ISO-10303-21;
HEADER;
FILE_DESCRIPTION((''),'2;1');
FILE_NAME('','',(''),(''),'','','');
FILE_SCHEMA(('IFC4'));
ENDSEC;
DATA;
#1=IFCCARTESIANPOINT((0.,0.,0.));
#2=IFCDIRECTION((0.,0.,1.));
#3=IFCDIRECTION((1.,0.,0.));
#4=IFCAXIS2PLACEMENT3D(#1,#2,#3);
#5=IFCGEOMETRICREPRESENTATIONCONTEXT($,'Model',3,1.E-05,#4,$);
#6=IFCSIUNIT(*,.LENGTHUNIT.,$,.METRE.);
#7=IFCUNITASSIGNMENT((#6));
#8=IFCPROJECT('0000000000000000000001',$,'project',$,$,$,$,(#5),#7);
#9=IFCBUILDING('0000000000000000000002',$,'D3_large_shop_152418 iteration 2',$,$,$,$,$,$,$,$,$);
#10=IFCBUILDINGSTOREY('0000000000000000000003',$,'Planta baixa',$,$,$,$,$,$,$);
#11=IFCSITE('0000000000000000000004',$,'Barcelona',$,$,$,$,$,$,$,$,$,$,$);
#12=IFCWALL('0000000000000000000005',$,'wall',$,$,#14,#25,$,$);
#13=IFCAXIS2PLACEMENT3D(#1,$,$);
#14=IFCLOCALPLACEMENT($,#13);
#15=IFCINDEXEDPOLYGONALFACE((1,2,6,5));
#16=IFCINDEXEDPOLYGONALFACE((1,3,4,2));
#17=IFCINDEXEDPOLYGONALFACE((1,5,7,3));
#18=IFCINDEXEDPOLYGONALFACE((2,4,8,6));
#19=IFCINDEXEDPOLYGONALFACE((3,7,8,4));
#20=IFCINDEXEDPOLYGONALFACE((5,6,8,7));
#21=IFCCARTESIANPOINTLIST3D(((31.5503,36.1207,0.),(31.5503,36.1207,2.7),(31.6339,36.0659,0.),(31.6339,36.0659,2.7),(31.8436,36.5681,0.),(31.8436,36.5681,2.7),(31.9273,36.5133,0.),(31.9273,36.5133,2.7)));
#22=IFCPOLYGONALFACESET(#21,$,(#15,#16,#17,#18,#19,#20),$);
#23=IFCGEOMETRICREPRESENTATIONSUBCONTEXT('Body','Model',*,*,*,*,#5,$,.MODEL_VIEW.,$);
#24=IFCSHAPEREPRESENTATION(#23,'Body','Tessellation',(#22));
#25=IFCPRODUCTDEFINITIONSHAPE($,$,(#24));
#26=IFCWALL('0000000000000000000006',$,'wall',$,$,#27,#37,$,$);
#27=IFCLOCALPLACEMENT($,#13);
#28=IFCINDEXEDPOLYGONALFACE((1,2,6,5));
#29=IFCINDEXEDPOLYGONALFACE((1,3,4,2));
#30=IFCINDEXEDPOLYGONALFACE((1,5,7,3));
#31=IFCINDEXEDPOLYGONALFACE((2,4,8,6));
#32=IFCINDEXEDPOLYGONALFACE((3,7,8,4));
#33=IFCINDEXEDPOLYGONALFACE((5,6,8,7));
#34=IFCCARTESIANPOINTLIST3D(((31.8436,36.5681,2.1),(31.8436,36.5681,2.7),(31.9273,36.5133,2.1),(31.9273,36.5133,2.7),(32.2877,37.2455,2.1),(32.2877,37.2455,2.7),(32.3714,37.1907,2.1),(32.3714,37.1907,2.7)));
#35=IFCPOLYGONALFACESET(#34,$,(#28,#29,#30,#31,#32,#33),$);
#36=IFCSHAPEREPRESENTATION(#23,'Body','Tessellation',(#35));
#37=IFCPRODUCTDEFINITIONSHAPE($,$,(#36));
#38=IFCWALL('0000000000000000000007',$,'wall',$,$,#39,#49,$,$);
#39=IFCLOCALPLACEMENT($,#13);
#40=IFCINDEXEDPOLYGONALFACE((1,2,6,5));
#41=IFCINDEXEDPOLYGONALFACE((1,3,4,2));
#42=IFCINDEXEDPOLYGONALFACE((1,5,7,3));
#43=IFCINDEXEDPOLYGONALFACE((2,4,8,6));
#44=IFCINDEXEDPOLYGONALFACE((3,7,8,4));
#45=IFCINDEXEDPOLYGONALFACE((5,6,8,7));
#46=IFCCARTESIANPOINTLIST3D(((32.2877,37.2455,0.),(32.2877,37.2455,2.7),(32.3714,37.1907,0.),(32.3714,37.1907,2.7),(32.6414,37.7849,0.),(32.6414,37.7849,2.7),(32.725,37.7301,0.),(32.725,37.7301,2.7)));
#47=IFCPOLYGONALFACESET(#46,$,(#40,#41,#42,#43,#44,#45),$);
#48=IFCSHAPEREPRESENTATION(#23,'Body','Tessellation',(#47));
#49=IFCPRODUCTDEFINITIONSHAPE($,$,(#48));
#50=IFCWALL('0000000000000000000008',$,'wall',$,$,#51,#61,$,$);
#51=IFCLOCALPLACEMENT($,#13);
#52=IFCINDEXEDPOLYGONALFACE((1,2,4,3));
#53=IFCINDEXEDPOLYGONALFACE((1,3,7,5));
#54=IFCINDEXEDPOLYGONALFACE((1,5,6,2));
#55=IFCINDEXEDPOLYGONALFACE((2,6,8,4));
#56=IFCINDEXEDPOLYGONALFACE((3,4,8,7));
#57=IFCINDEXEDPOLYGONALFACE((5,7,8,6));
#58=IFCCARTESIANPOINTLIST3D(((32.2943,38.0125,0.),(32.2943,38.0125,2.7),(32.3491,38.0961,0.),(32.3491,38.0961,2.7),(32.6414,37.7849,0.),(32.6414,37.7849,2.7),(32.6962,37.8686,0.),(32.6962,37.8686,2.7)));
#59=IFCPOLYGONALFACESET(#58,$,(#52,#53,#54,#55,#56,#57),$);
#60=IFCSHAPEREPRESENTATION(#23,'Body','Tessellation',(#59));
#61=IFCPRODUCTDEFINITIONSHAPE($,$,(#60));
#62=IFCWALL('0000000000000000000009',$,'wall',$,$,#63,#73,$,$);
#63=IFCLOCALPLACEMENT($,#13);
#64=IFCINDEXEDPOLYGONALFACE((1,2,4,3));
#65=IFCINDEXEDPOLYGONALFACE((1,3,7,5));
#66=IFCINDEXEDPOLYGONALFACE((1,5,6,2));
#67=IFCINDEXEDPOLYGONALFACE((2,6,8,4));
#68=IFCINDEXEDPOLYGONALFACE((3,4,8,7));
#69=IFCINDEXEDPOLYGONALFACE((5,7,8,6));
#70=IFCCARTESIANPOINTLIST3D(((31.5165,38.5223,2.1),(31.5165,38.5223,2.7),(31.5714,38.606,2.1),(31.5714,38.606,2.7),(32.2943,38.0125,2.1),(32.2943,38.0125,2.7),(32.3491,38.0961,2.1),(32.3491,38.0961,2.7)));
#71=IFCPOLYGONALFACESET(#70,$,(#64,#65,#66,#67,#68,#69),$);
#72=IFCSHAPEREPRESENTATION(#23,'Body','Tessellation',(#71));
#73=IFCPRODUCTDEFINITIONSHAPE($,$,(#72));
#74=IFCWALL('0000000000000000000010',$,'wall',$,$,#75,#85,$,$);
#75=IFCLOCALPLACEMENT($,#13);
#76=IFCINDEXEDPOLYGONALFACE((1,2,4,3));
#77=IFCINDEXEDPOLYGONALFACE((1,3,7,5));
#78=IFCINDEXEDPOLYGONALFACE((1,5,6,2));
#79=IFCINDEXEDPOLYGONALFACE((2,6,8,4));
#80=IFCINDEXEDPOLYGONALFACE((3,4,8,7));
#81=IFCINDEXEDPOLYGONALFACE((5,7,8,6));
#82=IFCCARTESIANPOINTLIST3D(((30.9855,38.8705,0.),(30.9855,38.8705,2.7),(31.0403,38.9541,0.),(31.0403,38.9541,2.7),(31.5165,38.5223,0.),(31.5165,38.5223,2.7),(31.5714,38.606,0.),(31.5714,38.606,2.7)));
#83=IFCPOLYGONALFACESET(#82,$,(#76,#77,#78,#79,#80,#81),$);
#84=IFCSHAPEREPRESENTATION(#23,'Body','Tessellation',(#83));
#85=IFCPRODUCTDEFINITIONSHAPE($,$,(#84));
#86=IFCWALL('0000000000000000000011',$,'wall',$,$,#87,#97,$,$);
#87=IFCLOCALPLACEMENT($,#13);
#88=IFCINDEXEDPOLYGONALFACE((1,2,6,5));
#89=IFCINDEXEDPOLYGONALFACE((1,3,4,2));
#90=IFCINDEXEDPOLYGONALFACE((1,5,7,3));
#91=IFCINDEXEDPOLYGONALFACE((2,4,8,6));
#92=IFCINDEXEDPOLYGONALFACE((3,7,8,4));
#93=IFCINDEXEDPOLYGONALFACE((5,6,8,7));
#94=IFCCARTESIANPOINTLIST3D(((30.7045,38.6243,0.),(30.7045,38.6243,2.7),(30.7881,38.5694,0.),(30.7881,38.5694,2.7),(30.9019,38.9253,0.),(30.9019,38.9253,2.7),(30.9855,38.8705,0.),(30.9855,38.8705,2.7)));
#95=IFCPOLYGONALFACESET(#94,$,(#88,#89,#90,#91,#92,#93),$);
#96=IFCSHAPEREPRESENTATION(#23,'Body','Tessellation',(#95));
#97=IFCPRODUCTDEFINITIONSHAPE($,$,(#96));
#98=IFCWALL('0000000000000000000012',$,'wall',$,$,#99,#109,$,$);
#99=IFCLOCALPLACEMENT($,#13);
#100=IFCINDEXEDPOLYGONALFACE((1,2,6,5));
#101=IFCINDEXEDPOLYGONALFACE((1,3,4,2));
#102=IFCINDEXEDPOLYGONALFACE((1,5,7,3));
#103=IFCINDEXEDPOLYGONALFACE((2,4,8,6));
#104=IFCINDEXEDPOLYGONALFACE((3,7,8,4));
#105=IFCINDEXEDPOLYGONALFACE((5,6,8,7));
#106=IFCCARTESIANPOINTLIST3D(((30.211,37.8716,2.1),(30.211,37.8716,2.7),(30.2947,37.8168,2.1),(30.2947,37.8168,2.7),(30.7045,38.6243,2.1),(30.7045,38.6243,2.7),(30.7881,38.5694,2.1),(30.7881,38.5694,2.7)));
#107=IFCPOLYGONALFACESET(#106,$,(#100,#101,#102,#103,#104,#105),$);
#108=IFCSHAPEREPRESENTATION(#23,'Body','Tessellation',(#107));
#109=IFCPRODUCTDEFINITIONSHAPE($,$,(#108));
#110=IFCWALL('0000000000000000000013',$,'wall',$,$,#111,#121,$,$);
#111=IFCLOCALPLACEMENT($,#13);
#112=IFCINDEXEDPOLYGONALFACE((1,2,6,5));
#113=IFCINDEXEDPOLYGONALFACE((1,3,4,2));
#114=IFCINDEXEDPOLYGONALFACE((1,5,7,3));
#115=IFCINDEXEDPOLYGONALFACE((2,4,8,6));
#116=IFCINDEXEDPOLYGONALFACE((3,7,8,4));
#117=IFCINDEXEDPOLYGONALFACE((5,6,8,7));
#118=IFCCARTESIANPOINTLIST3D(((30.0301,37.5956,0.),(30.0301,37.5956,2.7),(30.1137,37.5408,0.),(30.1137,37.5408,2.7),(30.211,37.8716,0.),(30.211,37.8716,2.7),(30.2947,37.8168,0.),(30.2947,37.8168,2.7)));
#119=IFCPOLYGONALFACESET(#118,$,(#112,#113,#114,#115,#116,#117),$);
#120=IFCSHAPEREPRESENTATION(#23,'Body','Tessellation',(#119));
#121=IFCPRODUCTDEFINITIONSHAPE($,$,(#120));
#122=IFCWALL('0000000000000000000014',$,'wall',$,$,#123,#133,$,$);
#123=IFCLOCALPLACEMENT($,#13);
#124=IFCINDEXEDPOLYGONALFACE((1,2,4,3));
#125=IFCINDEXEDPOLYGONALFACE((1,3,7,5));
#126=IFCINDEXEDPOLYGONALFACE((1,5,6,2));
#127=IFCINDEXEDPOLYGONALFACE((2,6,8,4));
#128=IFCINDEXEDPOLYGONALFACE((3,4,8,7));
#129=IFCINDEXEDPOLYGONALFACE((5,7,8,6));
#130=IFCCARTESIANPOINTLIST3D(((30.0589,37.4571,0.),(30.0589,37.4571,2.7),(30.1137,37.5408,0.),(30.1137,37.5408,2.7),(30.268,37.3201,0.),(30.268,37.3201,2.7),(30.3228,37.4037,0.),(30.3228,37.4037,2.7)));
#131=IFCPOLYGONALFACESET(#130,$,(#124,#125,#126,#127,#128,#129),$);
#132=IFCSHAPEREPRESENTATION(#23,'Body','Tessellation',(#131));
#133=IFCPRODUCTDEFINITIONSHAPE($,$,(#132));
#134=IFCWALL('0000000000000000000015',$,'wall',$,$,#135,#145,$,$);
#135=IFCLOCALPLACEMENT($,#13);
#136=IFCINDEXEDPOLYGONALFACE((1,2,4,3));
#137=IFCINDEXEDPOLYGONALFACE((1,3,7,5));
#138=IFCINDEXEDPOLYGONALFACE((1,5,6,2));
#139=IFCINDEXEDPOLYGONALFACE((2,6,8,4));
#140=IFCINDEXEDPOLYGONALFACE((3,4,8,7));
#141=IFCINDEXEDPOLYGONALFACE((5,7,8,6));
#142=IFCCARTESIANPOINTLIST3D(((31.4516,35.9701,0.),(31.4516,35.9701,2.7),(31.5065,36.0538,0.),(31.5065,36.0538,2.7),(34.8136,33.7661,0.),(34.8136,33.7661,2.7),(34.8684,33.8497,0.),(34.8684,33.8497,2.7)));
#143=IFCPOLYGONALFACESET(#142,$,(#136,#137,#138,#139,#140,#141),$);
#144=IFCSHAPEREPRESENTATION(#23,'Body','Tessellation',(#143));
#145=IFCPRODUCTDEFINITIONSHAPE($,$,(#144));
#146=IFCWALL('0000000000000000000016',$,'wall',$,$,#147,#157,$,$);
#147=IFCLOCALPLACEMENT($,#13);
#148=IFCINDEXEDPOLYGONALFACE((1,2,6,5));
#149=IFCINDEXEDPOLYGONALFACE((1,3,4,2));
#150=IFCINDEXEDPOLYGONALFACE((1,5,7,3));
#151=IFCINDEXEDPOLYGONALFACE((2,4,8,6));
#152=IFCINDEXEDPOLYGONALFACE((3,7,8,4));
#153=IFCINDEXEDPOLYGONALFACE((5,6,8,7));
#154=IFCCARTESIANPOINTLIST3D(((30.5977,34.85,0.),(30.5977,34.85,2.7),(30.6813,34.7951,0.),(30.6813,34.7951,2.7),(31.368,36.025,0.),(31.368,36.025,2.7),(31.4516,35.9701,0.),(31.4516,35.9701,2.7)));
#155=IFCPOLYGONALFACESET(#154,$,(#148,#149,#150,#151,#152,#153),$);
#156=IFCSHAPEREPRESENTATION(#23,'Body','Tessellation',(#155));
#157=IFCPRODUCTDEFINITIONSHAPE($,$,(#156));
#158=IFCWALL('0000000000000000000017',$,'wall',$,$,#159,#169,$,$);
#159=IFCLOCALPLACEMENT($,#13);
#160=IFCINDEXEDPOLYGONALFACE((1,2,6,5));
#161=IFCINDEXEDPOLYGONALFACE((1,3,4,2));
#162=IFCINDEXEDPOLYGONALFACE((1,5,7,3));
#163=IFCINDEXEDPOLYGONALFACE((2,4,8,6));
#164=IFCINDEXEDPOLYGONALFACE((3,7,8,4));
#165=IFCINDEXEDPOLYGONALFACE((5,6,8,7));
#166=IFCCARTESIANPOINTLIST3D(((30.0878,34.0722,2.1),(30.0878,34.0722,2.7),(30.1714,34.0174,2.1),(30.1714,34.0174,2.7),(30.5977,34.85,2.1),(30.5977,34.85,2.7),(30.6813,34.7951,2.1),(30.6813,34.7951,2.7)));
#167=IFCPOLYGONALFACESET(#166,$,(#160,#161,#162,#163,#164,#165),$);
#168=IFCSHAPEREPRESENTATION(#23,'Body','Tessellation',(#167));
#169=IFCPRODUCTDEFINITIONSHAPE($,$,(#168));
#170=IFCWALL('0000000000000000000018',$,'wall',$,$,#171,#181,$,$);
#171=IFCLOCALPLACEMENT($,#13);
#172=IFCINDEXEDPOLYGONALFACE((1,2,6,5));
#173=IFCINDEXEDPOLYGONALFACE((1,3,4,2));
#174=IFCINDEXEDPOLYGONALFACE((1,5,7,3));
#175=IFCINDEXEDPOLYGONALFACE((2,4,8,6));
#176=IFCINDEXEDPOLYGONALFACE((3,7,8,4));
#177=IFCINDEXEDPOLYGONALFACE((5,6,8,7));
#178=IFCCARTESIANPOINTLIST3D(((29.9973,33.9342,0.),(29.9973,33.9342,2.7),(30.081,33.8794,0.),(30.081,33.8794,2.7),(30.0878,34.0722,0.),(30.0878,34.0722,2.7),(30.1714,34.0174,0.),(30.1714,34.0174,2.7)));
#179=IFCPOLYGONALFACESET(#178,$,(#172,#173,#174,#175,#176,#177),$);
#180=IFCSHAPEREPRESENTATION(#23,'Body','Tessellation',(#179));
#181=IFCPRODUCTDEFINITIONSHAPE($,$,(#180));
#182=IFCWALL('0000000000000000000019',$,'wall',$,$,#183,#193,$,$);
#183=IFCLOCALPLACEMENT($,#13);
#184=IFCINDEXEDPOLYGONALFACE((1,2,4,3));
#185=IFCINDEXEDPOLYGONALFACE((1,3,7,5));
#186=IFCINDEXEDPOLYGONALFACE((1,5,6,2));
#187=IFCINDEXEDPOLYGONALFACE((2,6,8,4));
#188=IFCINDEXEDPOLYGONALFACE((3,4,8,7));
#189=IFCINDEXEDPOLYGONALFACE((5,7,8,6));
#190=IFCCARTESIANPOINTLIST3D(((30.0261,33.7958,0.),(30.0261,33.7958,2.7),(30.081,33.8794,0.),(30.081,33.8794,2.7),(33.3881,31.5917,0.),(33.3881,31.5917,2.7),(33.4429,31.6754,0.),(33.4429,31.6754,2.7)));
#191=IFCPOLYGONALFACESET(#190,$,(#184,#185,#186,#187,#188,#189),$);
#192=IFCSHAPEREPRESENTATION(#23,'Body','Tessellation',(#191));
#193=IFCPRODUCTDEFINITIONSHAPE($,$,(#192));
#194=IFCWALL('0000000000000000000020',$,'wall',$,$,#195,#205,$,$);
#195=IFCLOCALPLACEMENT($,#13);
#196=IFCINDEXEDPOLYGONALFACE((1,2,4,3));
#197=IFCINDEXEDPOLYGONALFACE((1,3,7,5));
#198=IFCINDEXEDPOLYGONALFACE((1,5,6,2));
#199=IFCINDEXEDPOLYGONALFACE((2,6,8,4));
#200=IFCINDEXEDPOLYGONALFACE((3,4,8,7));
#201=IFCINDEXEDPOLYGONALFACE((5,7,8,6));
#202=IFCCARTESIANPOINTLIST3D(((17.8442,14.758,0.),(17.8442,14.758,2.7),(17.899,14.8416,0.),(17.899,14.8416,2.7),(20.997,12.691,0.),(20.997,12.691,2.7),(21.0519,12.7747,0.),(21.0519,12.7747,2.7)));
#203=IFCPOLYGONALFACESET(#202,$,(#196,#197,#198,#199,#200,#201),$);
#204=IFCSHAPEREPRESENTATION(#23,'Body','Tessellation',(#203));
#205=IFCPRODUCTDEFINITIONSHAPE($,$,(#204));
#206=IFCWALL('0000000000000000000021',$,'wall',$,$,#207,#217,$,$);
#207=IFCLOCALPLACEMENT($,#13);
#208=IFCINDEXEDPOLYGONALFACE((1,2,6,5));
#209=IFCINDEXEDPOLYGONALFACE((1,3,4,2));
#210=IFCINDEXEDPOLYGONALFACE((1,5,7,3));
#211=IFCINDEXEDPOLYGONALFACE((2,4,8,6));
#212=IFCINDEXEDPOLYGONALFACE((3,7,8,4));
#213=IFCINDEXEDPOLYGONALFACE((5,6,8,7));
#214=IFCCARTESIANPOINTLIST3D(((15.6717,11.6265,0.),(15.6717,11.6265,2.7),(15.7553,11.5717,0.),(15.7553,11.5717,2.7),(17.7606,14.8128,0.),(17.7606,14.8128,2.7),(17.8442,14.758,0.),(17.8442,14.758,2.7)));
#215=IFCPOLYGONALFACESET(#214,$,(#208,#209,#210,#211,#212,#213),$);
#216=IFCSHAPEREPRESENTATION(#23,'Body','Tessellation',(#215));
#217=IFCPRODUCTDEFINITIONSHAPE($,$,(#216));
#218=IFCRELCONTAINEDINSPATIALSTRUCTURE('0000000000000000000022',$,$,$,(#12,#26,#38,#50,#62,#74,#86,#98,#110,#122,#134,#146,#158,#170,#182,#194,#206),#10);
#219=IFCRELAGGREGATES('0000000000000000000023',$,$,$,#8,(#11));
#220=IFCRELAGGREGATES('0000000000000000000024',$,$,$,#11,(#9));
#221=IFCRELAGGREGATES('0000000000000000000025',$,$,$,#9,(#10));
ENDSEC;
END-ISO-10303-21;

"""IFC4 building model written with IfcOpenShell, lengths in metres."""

from ifc_helpers import new_model, si_unit, frame, origin, origin_with_axes, place, context, subcontext, project, spatial, polyline, outline, extrude, element, save


model = new_model("IFC4")

# Units and contexts
model_context = context("Model", 3, precision=1e-05, world=origin_with_axes())
body_context = subcontext(model_context, "Body", "Model", "MODEL_VIEW")
ifc_project = project(units=[si_unit("LENGTHUNIT", "METRE")], contexts=[model_context])

# Site, building, storey
site = spatial("IfcSite", under=ifc_project, Name="Barcelona")
building = spatial("IfcBuilding", under=site, Name="D3_large_shop_152418 iteration 2")
storey = spatial("IfcBuildingStorey", under=building, Name="Planta baixa")

# Walls
wall_1_placement = place(None, origin_with_axes())
element("IfcWall", 1, at=wall_1_placement, inside=storey, Name="wall", context=body_context, shape_type="SweptSolid", body=[
    extrude(outline(polyline([(31.5503, 36.1207), (31.8436, 36.5681), (31.9273, 36.5133), (31.6339, 36.0659), (31.5503, 36.1207)])), origin(), (0.0, 0.0, 1.0), 2.7),
])
wall_2_placement = place(None, origin_with_axes())
element("IfcWall", 2, at=wall_2_placement, inside=storey, Name="wall", context=body_context, shape_type="SweptSolid", body=[
    extrude(outline(polyline([(31.8436, 36.5681), (32.2877, 37.2455), (32.3714, 37.1907), (31.9273, 36.5133), (31.8436, 36.5681)])), frame((0.0, 0.0, 2.1)), (0.0, 0.0, 1.0), 0.6),
])
wall_3_placement = place(None, origin_with_axes())
element("IfcWall", 3, at=wall_3_placement, inside=storey, Name="wall", context=body_context, shape_type="SweptSolid", body=[
    extrude(outline(polyline([(32.2877, 37.2455), (32.6414, 37.7849), (32.725, 37.7301), (32.3714, 37.1907), (32.2877, 37.2455)])), origin(), (0.0, 0.0, 1.0), 2.7),
])
wall_4_placement = place(None, origin_with_axes())
element("IfcWall", 4, at=wall_4_placement, inside=storey, Name="wall", context=body_context, shape_type="SweptSolid", body=[
    extrude(outline(polyline([(32.6414, 37.7849), (32.2943, 38.0125), (32.3491, 38.0961), (32.6962, 37.8686), (32.6414, 37.7849)])), origin(), (0.0, 0.0, 1.0), 2.7),
])
wall_5_placement = place(None, origin_with_axes())
element("IfcWall", 5, at=wall_5_placement, inside=storey, Name="wall", context=body_context, shape_type="SweptSolid", body=[
    extrude(outline(polyline([(32.2943, 38.0125), (31.5165, 38.5223), (31.5714, 38.606), (32.3491, 38.0961), (32.2943, 38.0125)])), frame((0.0, 0.0, 2.1)), (0.0, 0.0, 1.0), 0.6),
])
wall_6_placement = place(None, origin_with_axes())
element("IfcWall", 6, at=wall_6_placement, inside=storey, Name="wall", context=body_context, shape_type="SweptSolid", body=[
    extrude(outline(polyline([(31.5165, 38.5223), (30.9855, 38.8705), (31.0403, 38.9541), (31.5714, 38.606), (31.5165, 38.5223)])), origin(), (0.0, 0.0, 1.0), 2.7),
])
wall_7_placement = place(None, origin_with_axes())
element("IfcWall", 7, at=wall_7_placement, inside=storey, Name="wall", context=body_context, shape_type="SweptSolid", body=[
    extrude(outline(polyline([(30.9855, 38.8705), (30.7881, 38.5694), (30.7045, 38.6243), (30.9019, 38.9253), (30.9855, 38.8705)])), origin(), (0.0, 0.0, 1.0), 2.7),
])
wall_8_placement = place(None, origin_with_axes())
element("IfcWall", 8, at=wall_8_placement, inside=storey, Name="wall", context=body_context, shape_type="SweptSolid", body=[
    extrude(outline(polyline([(30.7881, 38.5694), (30.2947, 37.8168), (30.211, 37.8716), (30.7045, 38.6243), (30.7881, 38.5694)])), frame((0.0, 0.0, 2.1)), (0.0, 0.0, 1.0), 0.6),
])
wall_9_placement = place(None, origin_with_axes())
element("IfcWall", 9, at=wall_9_placement, inside=storey, Name="wall", context=body_context, shape_type="SweptSolid", body=[
    extrude(outline(polyline([(30.2947, 37.8168), (30.1137, 37.5408), (30.0301, 37.5956), (30.211, 37.8716), (30.2947, 37.8168)])), origin(), (0.0, 0.0, 1.0), 2.7),
])
wall_10_placement = place(None, origin_with_axes())
element("IfcWall", 10, at=wall_10_placement, inside=storey, Name="wall", context=body_context, shape_type="SweptSolid", body=[
    extrude(outline(polyline([(30.1137, 37.5408), (30.3228, 37.4037), (30.268, 37.3201), (30.0589, 37.4571), (30.1137, 37.5408)])), origin(), (0.0, 0.0, 1.0), 2.7),
])
wall_11_placement = place(None, origin_with_axes())
element("IfcWall", 11, at=wall_11_placement, inside=storey, Name="wall", context=body_context, shape_type="SweptSolid", body=[
    extrude(outline(polyline([(34.8136, 33.7661), (31.4516, 35.9701), (31.5065, 36.0538), (34.8684, 33.8497), (34.8136, 33.7661)])), origin(), (0.0, 0.0, 1.0), 2.7),
])
wall_12_placement = place(None, origin_with_axes())
element("IfcWall", 12, at=wall_12_placement, inside=storey, Name="wall", context=body_context, shape_type="SweptSolid", body=[
    extrude(outline(polyline([(31.4516, 35.9701), (30.6813, 34.7951), (30.5977, 34.85), (31.368, 36.025), (31.4516, 35.9701)])), origin(), (0.0, 0.0, 1.0), 2.7),
])
wall_13_placement = place(None, origin_with_axes())
element("IfcWall", 13, at=wall_13_placement, inside=storey, Name="wall", context=body_context, shape_type="SweptSolid", body=[
    extrude(outline(polyline([(30.6813, 34.7951), (30.1714, 34.0174), (30.0878, 34.0722), (30.5977, 34.85), (30.6813, 34.7951)])), frame((0.0, 0.0, 2.1)), (0.0, 0.0, 1.0), 0.6),
])
wall_14_placement = place(None, origin_with_axes())
element("IfcWall", 14, at=wall_14_placement, inside=storey, Name="wall", context=body_context, shape_type="SweptSolid", body=[
    extrude(outline(polyline([(30.1714, 34.0174), (30.081, 33.8794), (29.9973, 33.9342), (30.0878, 34.0722), (30.1714, 34.0174)])), origin(), (0.0, 0.0, 1.0), 2.7),
])
wall_15_placement = place(None, origin_with_axes())
element("IfcWall", 15, at=wall_15_placement, inside=storey, Name="wall", context=body_context, shape_type="SweptSolid", body=[
    extrude(outline(polyline([(30.081, 33.8794), (33.4429, 31.6754), (33.3881, 31.5917), (30.0261, 33.7958), (30.081, 33.8794)])), origin(), (0.0, 0.0, 1.0), 2.7),
])
wall_16_placement = place(None, origin_with_axes())
element("IfcWall", 16, at=wall_16_placement, inside=storey, Name="wall", context=body_context, shape_type="SweptSolid", body=[
    extrude(outline(polyline([(20.997, 12.691), (17.8442, 14.758), (17.899, 14.8416), (21.0519, 12.7747), (20.997, 12.691)])), origin(), (0.0, 0.0, 1.0), 2.7),
])
wall_17_placement = place(None, origin_with_axes())
element("IfcWall", 17, at=wall_17_placement, inside=storey, Name="wall", context=body_context, shape_type="SweptSolid", body=[
    extrude(outline(polyline([(17.8442, 14.758), (15.7553, 11.5717), (15.6717, 11.6265), (17.7606, 14.8128), (17.8442, 14.758)])), origin(), (0.0, 0.0, 1.0), 2.7),
])

save(model, "model.ifc")
